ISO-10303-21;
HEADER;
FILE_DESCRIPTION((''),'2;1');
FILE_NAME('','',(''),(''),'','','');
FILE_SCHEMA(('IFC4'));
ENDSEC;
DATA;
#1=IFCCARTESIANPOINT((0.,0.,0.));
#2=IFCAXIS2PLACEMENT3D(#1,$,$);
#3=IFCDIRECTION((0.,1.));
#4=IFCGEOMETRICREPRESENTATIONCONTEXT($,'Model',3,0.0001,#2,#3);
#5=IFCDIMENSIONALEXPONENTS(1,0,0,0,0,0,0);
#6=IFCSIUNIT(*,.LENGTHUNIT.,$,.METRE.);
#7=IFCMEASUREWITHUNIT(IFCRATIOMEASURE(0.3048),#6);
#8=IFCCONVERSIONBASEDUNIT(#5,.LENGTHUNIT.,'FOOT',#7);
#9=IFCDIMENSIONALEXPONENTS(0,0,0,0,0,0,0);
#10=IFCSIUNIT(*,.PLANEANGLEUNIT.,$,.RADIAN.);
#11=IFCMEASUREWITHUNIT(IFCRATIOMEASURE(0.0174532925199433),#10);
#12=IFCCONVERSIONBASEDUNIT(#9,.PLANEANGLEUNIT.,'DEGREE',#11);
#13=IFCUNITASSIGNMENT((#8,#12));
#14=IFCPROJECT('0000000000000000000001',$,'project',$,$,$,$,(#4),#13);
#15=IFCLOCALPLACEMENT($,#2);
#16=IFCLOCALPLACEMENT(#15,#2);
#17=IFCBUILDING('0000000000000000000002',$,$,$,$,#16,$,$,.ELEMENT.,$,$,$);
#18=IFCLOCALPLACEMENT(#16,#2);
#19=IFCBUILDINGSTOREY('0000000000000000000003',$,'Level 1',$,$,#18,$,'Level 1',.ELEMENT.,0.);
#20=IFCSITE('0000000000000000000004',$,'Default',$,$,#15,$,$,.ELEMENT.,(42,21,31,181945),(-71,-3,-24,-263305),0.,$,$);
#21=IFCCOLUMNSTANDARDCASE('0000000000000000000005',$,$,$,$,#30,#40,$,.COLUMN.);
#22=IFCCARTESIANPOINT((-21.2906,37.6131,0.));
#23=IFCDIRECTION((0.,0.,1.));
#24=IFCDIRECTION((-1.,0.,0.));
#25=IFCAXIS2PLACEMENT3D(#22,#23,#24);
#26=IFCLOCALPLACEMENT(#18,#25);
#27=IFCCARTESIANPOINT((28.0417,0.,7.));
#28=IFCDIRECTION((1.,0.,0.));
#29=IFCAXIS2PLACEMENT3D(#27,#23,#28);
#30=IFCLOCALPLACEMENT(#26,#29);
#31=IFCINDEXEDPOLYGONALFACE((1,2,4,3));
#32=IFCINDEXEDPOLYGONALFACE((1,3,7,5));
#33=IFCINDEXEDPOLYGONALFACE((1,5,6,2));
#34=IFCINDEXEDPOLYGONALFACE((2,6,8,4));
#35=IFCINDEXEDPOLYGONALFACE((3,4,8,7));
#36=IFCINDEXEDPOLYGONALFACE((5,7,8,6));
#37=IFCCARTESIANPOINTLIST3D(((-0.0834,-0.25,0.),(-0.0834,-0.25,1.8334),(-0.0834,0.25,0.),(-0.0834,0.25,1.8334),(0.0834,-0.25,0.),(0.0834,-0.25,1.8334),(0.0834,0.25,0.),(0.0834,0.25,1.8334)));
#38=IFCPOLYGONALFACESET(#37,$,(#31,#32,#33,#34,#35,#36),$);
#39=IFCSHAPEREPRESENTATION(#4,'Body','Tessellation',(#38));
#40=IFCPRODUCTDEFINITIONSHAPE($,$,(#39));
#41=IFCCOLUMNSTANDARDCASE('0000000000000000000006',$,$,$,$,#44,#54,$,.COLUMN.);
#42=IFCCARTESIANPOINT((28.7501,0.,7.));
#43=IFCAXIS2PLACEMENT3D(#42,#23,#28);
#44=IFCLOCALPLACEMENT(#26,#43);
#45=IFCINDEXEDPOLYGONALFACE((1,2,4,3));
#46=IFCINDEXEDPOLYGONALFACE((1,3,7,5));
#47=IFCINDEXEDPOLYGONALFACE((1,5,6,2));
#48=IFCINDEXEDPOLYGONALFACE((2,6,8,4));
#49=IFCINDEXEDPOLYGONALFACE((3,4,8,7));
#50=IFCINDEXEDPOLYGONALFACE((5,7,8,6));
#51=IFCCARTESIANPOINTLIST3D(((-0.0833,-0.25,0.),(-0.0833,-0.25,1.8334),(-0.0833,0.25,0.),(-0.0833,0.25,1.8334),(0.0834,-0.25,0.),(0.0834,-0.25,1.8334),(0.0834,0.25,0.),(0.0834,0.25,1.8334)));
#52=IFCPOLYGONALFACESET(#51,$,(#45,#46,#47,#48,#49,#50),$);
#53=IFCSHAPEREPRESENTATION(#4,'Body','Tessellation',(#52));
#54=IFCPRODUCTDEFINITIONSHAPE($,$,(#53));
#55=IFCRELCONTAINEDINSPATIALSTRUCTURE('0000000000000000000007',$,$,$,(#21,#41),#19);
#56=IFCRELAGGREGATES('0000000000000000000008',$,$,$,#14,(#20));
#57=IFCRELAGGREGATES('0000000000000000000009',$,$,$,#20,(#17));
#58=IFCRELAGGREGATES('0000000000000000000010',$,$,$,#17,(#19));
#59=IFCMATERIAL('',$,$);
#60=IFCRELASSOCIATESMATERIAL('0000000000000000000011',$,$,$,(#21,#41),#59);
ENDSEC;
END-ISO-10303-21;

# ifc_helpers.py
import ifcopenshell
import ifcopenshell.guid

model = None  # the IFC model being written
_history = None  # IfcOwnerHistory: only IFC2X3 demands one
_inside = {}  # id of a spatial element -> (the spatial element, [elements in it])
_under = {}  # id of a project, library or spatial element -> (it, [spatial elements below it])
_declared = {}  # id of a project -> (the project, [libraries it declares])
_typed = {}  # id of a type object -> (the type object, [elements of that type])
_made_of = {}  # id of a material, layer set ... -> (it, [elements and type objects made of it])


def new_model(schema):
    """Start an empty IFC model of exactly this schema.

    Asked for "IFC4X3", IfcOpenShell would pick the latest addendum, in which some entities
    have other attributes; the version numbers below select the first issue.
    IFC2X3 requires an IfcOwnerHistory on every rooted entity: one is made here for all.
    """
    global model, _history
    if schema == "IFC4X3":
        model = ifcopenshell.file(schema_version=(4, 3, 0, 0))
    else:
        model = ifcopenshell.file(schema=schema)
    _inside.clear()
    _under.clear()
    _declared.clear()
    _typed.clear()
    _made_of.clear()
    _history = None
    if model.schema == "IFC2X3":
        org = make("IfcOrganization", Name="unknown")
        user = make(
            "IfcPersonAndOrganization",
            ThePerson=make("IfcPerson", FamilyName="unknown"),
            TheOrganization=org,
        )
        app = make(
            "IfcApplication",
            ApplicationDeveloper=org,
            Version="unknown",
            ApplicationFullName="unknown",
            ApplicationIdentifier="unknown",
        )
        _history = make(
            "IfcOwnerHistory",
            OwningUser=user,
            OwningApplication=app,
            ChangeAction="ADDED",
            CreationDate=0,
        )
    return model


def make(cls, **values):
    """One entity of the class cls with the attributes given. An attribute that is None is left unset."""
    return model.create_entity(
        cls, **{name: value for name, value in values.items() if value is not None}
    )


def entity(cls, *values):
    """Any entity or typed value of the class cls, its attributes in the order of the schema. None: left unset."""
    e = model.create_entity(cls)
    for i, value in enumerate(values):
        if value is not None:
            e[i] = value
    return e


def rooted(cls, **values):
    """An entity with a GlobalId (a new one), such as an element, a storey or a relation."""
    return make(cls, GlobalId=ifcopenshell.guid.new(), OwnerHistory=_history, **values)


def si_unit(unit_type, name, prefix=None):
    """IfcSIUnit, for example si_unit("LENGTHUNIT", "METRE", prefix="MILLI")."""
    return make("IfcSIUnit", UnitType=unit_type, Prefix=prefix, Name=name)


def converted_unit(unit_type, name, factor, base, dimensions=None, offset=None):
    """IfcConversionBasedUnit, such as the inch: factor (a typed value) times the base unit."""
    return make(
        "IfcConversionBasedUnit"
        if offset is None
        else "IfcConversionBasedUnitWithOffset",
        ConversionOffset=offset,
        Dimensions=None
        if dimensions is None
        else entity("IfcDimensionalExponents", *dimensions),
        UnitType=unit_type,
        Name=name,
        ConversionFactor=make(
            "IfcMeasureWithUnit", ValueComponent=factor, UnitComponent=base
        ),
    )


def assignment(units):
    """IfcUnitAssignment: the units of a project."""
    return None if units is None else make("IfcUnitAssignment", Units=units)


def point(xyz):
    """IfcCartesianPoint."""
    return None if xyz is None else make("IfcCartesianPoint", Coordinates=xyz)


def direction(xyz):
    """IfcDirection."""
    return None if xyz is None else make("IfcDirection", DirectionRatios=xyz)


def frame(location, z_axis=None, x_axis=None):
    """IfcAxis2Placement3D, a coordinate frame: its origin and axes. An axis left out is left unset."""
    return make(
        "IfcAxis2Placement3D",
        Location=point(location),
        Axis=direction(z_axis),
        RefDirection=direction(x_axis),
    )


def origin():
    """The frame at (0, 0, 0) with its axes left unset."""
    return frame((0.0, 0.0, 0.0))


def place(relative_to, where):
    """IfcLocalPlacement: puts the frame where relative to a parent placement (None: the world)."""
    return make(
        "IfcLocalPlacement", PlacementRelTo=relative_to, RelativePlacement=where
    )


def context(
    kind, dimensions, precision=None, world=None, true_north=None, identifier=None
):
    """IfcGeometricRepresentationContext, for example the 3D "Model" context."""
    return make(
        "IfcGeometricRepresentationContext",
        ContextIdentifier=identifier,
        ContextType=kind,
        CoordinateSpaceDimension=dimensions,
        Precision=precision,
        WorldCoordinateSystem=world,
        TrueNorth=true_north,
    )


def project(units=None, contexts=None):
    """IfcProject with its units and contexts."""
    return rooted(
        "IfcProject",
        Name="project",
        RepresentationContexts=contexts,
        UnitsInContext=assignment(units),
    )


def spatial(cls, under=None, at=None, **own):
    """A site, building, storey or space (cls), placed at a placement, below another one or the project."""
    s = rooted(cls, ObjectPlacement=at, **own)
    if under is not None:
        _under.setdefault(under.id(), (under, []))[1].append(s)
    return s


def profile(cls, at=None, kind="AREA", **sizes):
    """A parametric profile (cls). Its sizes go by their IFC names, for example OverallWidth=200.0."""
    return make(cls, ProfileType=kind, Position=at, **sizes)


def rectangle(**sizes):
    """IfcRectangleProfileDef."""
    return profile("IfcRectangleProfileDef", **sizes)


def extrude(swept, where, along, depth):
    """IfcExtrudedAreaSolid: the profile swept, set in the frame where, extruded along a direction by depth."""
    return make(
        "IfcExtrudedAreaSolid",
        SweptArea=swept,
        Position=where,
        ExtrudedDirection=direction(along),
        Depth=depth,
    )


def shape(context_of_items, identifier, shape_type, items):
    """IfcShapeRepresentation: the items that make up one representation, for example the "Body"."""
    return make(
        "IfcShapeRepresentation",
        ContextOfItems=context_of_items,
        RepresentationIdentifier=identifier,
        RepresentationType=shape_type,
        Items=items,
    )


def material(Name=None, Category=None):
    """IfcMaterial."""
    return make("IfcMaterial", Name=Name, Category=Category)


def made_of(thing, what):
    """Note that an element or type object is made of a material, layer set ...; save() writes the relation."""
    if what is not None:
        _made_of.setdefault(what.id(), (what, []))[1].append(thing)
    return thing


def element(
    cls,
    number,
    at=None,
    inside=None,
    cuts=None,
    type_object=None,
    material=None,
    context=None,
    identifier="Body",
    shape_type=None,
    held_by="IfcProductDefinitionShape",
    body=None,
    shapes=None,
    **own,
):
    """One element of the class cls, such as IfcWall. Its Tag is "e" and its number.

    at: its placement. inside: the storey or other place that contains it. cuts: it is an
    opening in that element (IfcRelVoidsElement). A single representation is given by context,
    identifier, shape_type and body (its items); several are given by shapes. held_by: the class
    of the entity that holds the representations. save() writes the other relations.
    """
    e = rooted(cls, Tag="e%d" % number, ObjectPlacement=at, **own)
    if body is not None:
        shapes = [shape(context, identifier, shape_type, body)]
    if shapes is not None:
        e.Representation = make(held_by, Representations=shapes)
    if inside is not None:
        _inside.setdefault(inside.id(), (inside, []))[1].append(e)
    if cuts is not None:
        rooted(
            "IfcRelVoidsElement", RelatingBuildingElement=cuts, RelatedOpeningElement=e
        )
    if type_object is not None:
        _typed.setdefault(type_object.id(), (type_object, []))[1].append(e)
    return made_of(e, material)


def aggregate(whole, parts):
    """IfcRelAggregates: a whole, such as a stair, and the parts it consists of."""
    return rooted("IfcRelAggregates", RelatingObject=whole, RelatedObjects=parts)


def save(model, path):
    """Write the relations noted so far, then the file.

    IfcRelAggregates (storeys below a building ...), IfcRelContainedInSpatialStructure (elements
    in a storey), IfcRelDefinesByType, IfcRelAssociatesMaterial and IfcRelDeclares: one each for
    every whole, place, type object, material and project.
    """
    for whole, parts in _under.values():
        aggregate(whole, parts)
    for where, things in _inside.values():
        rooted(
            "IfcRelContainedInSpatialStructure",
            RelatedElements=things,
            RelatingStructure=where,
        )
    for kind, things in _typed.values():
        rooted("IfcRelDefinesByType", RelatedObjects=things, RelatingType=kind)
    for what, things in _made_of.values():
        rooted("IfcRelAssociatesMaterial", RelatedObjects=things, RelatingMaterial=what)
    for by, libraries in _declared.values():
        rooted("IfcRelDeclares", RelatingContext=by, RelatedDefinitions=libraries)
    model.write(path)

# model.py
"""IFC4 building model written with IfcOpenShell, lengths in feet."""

from ifc_helpers import new_model, entity, si_unit, converted_unit, direction, frame, origin, place, context, project, spatial, rectangle, extrude, material, element, save


model = new_model("IFC4")

# Units and contexts
model_context = context("Model", 3, precision=0.0001, world=origin(), true_north=direction((0.0, 1.0)))
ifc_project = project(units=[converted_unit("LENGTHUNIT", "FOOT", entity("IfcRatioMeasure", 0.3048), si_unit("LENGTHUNIT", "METRE"), dimensions=[1, 0, 0, 0, 0, 0, 0]), converted_unit("PLANEANGLEUNIT", "DEGREE", entity("IfcRatioMeasure", 0.0174532925199433), si_unit("PLANEANGLEUNIT", "RADIAN"), dimensions=[0, 0, 0, 0, 0, 0, 0])], contexts=[model_context])

# Site, building, storey
site_placement = place(None, origin())
site = spatial("IfcSite", under=ifc_project, at=site_placement, Name="Default", CompositionType="ELEMENT", RefLatitude=(42, 21, 31, 181945), RefLongitude=(-71, -3, -24, -263305), RefElevation=0.0)
building_placement = place(site_placement, origin())
building = spatial("IfcBuilding", under=site, at=building_placement, CompositionType="ELEMENT")
storey_placement = place(building_placement, origin())
storey = spatial("IfcBuildingStorey", under=building, at=storey_placement, Name="Level 1", LongName="Level 1", CompositionType="ELEMENT", Elevation=0.0)

# Columns
ifc_material_1 = material(Name="")
placement_1 = place(storey_placement, frame((-21.2906, 37.6131, 0.0), z_axis=(0.0, 0.0, 1.0), x_axis=(-1.0, 0.0, 0.0)))
for number, where, z_axis, x_axis in (
    (1, (28.0417, 0.0, 7.0), (0.0, 0.0, 1.0), (1.0, 0.0, 0.0)),
    (2, (28.7501, 0.0, 7.0), (0.0, 0.0, 1.0), (1.0, 0.0, 0.0)),
):
    element("IfcColumnStandardCase", number, at=place(placement_1, frame(where, z_axis=z_axis, x_axis=x_axis)), inside=storey, material=ifc_material_1, PredefinedType="COLUMN", context=model_context, shape_type="SweptSolid", body=[
        extrude(rectangle(XDim=0.1667, YDim=0.5), origin(), (0.0, 0.0, 1.0), 1.8334),
    ])

save(model, "model.ifc")
